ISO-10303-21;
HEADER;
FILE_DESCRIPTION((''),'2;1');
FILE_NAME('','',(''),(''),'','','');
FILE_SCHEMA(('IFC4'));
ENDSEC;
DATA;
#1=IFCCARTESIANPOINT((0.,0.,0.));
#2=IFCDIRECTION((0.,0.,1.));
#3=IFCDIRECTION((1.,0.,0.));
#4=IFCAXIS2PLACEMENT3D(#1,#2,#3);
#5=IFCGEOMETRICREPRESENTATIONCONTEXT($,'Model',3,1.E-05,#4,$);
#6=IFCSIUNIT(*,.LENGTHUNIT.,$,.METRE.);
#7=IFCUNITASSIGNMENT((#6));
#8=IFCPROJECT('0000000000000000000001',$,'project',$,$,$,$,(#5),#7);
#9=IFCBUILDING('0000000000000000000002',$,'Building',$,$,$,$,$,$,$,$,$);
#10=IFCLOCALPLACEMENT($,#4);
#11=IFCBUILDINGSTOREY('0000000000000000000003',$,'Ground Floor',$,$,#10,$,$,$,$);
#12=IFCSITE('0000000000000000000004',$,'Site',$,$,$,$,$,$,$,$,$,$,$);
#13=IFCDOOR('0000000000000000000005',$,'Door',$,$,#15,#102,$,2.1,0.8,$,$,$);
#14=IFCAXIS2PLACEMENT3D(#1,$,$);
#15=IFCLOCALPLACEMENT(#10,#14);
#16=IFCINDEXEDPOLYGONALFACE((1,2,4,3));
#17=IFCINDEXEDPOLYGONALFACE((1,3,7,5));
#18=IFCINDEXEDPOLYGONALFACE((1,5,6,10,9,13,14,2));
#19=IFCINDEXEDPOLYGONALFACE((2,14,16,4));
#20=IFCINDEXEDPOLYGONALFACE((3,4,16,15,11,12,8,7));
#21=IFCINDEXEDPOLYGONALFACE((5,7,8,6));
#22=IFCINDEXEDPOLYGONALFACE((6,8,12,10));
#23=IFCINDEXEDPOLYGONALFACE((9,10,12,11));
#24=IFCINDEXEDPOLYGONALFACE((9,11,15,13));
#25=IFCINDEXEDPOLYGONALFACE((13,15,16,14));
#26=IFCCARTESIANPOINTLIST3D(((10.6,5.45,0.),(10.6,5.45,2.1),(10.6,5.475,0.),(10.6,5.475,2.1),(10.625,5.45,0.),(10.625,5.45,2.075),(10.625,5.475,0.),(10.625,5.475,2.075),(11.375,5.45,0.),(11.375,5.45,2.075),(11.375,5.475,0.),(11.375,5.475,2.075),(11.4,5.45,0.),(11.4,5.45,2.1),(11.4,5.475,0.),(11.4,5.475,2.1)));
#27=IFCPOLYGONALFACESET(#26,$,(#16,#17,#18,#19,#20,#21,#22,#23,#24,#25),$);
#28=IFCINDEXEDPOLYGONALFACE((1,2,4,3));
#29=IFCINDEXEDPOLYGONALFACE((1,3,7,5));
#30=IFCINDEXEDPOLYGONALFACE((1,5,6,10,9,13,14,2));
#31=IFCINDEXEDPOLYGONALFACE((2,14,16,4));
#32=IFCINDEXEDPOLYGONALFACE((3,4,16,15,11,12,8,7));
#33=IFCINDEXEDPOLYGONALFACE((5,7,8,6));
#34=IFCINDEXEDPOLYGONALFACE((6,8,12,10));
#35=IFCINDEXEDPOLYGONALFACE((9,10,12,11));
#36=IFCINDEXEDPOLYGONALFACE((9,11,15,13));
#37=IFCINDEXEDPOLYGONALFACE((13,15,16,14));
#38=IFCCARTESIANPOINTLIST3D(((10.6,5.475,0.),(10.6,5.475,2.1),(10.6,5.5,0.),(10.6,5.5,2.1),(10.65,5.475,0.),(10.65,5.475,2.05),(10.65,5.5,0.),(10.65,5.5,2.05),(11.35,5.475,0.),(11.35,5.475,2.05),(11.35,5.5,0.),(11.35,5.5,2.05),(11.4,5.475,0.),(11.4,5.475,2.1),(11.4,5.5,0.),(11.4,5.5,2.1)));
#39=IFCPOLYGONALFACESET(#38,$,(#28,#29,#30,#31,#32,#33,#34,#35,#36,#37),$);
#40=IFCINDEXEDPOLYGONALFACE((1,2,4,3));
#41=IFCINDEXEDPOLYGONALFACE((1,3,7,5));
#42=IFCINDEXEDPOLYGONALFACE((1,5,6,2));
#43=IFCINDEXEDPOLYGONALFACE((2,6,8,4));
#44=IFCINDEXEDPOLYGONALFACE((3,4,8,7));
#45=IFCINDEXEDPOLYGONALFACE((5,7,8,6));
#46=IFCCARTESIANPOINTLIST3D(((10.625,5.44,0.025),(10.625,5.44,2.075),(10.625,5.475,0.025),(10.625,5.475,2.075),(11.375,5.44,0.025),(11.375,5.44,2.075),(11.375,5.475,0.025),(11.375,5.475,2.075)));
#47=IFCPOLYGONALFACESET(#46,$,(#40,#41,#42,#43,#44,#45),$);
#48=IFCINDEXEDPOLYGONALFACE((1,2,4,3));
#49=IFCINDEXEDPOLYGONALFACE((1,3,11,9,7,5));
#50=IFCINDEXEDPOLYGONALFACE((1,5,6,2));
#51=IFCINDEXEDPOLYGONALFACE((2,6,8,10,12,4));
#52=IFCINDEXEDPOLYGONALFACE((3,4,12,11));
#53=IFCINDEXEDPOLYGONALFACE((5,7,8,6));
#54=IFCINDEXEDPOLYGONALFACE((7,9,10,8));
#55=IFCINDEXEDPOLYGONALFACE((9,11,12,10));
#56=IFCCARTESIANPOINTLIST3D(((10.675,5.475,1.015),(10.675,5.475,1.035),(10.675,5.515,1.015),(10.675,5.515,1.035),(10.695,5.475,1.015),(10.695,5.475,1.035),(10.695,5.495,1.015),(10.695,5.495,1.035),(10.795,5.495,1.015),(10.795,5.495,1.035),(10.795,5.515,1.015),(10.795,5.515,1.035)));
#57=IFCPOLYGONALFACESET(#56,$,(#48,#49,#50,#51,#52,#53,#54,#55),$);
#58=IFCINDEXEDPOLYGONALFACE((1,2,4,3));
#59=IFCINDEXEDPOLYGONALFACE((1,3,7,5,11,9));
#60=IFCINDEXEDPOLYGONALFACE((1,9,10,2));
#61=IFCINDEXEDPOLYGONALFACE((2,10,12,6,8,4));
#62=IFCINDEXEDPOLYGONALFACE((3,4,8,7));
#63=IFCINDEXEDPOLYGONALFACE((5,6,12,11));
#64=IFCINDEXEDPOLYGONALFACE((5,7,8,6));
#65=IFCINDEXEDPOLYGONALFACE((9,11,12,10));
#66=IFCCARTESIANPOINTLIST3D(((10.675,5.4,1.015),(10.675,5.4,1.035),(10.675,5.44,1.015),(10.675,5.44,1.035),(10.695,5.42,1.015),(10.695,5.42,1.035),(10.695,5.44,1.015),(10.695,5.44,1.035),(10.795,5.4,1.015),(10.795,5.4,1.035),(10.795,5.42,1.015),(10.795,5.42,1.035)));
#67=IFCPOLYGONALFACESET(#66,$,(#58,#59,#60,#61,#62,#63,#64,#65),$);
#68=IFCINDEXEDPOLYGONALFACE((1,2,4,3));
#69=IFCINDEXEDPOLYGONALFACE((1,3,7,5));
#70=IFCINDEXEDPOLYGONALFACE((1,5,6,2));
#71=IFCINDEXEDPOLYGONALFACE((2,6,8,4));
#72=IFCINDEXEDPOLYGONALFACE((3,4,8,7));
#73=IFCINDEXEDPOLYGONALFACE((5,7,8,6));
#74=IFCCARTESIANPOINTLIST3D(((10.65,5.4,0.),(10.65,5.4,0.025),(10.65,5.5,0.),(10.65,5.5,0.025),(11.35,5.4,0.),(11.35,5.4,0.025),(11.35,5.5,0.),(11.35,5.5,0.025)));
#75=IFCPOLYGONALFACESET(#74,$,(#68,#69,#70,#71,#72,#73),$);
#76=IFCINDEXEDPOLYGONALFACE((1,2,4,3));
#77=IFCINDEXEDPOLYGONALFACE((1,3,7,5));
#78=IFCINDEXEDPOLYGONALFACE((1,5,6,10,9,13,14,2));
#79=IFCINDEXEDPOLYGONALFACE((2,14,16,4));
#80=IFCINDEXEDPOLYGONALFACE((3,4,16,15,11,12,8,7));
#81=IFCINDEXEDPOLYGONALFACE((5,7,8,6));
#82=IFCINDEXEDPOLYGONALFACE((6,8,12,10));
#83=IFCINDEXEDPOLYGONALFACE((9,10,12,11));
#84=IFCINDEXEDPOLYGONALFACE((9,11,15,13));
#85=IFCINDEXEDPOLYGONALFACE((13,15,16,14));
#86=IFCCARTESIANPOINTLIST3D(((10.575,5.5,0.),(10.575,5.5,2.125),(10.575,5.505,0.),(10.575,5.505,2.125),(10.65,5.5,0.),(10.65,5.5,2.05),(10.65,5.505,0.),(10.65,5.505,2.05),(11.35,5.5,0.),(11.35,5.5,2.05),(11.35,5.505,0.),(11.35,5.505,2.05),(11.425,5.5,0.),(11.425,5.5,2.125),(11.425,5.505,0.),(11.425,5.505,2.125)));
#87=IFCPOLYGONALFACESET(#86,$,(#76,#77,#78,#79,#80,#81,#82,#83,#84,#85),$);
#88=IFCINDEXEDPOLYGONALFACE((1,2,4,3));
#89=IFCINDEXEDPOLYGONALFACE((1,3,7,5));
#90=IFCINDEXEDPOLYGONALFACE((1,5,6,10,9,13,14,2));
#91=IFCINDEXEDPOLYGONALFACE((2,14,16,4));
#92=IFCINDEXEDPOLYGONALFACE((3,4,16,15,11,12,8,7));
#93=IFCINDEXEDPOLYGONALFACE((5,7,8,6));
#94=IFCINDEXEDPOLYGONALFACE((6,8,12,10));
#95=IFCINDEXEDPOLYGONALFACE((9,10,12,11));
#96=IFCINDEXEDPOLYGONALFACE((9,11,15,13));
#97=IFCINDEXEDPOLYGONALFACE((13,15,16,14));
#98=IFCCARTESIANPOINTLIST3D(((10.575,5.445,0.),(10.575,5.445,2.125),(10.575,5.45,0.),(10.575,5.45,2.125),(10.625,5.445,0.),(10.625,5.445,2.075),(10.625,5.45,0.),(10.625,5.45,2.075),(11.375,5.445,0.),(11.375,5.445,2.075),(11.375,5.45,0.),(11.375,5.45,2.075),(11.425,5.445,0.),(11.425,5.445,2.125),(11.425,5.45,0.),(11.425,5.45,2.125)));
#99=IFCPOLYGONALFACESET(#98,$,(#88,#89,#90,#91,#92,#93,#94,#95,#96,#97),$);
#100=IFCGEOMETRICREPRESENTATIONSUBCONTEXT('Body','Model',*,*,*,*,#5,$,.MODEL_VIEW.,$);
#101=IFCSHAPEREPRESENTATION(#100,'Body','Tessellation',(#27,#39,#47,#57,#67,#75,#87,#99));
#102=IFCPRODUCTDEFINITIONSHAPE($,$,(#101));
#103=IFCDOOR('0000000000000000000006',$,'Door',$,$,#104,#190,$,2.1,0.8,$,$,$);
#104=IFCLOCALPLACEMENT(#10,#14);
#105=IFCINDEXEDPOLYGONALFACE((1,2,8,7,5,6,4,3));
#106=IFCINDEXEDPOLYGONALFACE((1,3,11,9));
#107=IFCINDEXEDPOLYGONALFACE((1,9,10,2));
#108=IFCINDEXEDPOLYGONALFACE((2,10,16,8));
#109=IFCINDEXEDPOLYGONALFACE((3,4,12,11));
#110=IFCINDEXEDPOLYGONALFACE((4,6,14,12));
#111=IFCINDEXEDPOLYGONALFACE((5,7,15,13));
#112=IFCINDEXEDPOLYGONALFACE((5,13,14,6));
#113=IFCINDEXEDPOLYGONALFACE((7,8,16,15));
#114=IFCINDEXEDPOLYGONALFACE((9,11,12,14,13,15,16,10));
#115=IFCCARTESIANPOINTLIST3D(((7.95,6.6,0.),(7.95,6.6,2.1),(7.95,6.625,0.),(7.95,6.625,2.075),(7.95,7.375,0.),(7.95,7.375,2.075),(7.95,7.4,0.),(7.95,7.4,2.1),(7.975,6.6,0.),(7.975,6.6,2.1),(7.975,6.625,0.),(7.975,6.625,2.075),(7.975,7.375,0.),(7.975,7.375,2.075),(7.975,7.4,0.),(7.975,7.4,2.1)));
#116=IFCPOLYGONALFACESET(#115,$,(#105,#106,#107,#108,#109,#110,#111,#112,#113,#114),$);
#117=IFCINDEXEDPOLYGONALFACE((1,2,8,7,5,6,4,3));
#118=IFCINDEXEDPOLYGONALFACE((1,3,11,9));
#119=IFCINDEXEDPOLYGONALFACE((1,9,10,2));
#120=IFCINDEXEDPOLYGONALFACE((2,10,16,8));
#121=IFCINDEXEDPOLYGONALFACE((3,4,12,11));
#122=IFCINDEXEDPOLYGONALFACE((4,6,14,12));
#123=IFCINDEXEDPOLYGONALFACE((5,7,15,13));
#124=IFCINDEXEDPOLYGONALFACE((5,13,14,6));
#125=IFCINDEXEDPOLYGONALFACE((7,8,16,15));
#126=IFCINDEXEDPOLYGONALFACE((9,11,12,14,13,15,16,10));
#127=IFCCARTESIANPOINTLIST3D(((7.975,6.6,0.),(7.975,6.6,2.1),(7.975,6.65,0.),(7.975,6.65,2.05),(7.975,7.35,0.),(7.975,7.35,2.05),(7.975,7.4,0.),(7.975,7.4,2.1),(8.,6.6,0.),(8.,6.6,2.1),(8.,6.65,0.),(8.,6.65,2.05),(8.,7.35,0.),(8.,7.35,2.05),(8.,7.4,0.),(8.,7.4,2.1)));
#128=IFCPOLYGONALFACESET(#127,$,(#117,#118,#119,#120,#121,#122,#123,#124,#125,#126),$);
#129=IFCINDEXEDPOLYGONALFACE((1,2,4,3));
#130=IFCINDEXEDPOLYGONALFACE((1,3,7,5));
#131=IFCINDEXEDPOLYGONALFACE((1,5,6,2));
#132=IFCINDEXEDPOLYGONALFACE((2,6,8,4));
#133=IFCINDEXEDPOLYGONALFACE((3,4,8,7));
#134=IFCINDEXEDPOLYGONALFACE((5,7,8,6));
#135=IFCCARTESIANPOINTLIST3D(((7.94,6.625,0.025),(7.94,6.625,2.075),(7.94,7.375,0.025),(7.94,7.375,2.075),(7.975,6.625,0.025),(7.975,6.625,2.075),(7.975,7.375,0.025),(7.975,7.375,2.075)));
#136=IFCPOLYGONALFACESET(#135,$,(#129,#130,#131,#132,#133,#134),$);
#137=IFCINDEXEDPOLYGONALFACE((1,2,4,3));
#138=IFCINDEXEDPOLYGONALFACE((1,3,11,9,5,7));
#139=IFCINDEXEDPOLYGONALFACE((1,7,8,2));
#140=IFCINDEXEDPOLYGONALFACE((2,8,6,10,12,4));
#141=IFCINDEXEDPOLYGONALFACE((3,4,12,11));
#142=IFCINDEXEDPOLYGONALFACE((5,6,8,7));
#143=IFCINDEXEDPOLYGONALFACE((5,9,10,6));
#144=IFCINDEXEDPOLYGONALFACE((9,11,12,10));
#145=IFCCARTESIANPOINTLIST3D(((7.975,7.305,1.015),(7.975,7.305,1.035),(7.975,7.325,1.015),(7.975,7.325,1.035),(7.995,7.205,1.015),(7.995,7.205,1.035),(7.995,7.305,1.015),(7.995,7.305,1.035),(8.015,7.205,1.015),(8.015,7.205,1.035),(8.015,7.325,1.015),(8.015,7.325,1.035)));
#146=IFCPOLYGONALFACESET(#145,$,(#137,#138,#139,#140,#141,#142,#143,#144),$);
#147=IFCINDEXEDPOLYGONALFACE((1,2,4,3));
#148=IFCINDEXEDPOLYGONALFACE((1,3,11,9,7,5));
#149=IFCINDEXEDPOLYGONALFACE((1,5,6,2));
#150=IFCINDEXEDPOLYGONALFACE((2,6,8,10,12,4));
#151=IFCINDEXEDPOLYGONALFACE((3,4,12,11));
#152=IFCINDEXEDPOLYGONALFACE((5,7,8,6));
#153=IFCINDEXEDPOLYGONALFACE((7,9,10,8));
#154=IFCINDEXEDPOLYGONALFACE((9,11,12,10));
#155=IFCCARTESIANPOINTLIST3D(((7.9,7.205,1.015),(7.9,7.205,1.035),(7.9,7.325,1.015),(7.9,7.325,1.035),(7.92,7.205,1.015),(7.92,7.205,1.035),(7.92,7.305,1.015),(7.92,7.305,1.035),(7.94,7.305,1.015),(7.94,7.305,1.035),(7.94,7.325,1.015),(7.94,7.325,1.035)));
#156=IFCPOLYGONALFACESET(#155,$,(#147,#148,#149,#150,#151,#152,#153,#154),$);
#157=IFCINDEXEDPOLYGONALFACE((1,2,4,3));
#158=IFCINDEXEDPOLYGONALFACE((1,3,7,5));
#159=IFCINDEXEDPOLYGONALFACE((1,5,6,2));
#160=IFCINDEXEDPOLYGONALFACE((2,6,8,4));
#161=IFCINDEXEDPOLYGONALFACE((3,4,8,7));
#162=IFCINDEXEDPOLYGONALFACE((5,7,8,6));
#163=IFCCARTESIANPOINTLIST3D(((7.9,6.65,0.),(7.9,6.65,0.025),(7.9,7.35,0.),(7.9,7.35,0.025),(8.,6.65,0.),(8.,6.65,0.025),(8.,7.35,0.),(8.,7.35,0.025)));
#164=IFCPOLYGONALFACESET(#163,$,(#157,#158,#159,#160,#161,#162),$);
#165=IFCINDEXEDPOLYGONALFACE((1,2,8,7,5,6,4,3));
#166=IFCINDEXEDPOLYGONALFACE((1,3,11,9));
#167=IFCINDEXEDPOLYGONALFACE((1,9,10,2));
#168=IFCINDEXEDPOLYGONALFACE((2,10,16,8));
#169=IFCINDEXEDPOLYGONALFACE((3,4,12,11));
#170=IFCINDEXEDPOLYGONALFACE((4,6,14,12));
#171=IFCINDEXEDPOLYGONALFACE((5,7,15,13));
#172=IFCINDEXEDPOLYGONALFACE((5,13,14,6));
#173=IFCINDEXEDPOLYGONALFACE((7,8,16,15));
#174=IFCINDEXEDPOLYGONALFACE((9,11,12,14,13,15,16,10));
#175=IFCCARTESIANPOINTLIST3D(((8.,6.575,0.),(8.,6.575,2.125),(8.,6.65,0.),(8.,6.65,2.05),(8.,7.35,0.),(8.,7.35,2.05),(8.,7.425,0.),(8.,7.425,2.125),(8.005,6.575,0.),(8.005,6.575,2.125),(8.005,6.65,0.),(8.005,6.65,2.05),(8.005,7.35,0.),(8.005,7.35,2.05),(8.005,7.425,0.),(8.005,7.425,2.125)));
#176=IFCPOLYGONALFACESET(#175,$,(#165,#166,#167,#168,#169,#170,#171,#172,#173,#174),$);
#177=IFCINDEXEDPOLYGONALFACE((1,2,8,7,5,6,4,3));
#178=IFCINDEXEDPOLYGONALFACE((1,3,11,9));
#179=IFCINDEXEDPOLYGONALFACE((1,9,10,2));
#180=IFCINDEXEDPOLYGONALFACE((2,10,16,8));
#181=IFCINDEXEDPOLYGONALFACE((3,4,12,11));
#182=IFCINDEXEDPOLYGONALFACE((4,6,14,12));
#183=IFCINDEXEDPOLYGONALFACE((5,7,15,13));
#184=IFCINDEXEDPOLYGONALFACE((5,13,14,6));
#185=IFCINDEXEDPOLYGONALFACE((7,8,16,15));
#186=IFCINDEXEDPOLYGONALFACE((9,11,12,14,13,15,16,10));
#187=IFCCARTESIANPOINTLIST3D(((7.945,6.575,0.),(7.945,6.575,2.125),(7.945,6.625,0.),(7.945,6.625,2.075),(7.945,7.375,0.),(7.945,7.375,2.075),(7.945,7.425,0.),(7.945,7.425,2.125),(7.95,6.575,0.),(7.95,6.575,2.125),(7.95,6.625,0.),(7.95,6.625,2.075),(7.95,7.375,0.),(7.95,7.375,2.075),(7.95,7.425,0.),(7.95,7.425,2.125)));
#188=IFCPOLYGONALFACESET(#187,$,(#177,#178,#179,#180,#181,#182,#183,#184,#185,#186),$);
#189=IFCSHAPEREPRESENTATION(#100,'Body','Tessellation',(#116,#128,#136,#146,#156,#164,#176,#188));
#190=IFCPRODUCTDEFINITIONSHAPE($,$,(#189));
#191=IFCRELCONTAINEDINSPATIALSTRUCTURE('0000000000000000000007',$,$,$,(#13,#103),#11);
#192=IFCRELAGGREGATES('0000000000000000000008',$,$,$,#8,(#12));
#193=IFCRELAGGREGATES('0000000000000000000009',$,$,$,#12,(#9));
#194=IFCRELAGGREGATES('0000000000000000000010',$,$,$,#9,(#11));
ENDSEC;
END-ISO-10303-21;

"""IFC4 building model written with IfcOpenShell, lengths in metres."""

from ifc_helpers import new_model, si_unit, frame, origin_with_axes, place, context, subcontext, project, spatial, line, indexed_curve, outline, extrude, element, save


model = new_model("IFC4")

# Units and contexts
model_context = context("Model", 3, precision=1e-05, world=origin_with_axes())
body_context = subcontext(model_context, "Body", "Model", "MODEL_VIEW")
ifc_project = project(units=[si_unit("LENGTHUNIT", "METRE")], contexts=[model_context])

# Site, building, storey
site = spatial("IfcSite", under=ifc_project, Name="Site")
building = spatial("IfcBuilding", under=site, Name="Building")
storey_placement = place(None, origin_with_axes())
storey = spatial("IfcBuildingStorey", under=building, at=storey_placement, Name="Ground Floor")

# Doors
door_1_placement = place(storey_placement, frame((11.4, 5.5, 0.0), z_axis=(0.0, 0.0, 1.0), x_axis=(-1.0, 0.0, 0.0)))
element("IfcDoor", 1, at=door_1_placement, inside=storey, Name="Door", OverallHeight=2.1, OverallWidth=0.8, context=body_context, shape_type="SweptSolid", body=[
    extrude(outline(indexed_curve([(0.0, 0.0), (0.0, 2.1), (0.8, 2.1), (0.8, 0.0), (0.775, 0.0), (0.775, 2.075), (0.025, 2.075), (0.025, 0.0)], segments=[line(1, 2, 3, 4, 5, 6, 7, 8, 1)])), frame((0.0, 0.025, 0.0), z_axis=(0.0, -1.0, 0.0), x_axis=(1.0, 0.0, 0.0)), (0.0, 0.0, -1.0), 0.025),
    extrude(outline(indexed_curve([(0.0, 0.0), (0.0, 2.1), (0.8, 2.1), (0.8, 0.0), (0.75, 0.0), (0.75, 2.05), (0.05, 2.05), (0.05, 0.0)], segments=[line(1, 2, 3, 4, 5, 6, 7, 8, 1)])), frame((0.0, 0.0, 0.0), z_axis=(0.0, -1.0, 0.0), x_axis=(1.0, 0.0, 0.0)), (0.0, 0.0, -1.0), 0.025),
    extrude(outline(indexed_curve([(0.0, 0.0), (0.75, 0.0), (0.75, 0.035), (0.0, 0.035)], segments=[line(1, 2, 3, 4, 1)])), frame((0.025, 0.025, 0.025), z_axis=(0.0, 0.0, 1.0), x_axis=(1.0, 0.0, 0.0)), (0.0, 0.0, 1.0), 2.05),
    extrude(outline(indexed_curve([(0.0, 0.0), (0.0, -0.04), (-0.12, -0.04), (-0.12, -0.02), (-0.02, -0.02), (-0.02, 0.0)], segments=[line(1, 2, 3, 4, 5, 6, 1)])), frame((0.725, 0.025, 1.015), z_axis=(0.0, 0.0, 1.0), x_axis=(1.0, 0.0, 0.0)), (0.0, 0.0, 1.0), 0.02),
    extrude(outline(indexed_curve([(0.0, 0.0), (0.0, 0.04), (-0.12, 0.04), (-0.12, 0.02), (-0.02, 0.02), (-0.02, 0.0)], segments=[line(1, 2, 3, 4, 5, 6, 1)])), frame((0.725, 0.06, 1.015), z_axis=(0.0, 0.0, 1.0), x_axis=(1.0, 0.0, 0.0)), (0.0, 0.0, 1.0), 0.02),
    extrude(outline(indexed_curve([(0.0, 0.0), (0.7, 0.0), (0.7, 0.1), (0.0, 0.1)], segments=[line(1, 2, 3, 4, 1)])), frame((0.05, 0.0, 0.0), z_axis=(0.0, 0.0, 1.0), x_axis=(1.0, 0.0, 0.0)), (0.0, 0.0, 1.0), 0.025),
    extrude(outline(indexed_curve([(0.0, 0.0), (0.0, 2.125), (0.85, 2.125), (0.85, 0.0), (0.775, 0.0), (0.775, 2.05), (0.075, 2.05), (0.075, 0.0)], segments=[line(1, 2, 3, 4, 5, 6, 7, 8, 1)])), frame((-0.025, -0.005, 0.0), z_axis=(0.0, -1.0, 0.0), x_axis=(1.0, 0.0, 0.0)), (0.0, 0.0, -1.0), 0.005),
    extrude(outline(indexed_curve([(0.0, 0.0), (0.0, 2.125), (0.85, 2.125), (0.85, 0.0), (0.8, 0.0), (0.8, 2.075), (0.05, 2.075), (0.05, 0.0)], segments=[line(1, 2, 3, 4, 5, 6, 7, 8, 1)])), frame((-0.025, 0.05, 0.0), z_axis=(0.0, -1.0, 0.0), x_axis=(1.0, 0.0, 0.0)), (0.0, 0.0, -1.0), 0.005),
])
door_2_placement = place(storey_placement, frame((8.0, 6.6, 0.0), z_axis=(0.0, 0.0, 1.0), x_axis=(0.0, 1.0, 0.0)))
element("IfcDoor", 2, at=door_2_placement, inside=storey, Name="Door", OverallHeight=2.1, OverallWidth=0.8, context=body_context, shape_type="SweptSolid", body=[
    extrude(outline(indexed_curve([(0.0, 0.0), (0.0, 2.1), (0.8, 2.1), (0.8, 0.0), (0.775, 0.0), (0.775, 2.075), (0.025, 2.075), (0.025, 0.0)], segments=[line(1, 2, 3, 4, 5, 6, 7, 8, 1)])), frame((0.0, 0.025, 0.0), z_axis=(0.0, -1.0, 0.0), x_axis=(1.0, 0.0, 0.0)), (0.0, 0.0, -1.0), 0.025),
    extrude(outline(indexed_curve([(0.0, 0.0), (0.0, 2.1), (0.8, 2.1), (0.8, 0.0), (0.75, 0.0), (0.75, 2.05), (0.05, 2.05), (0.05, 0.0)], segments=[line(1, 2, 3, 4, 5, 6, 7, 8, 1)])), frame((0.0, 0.0, 0.0), z_axis=(0.0, -1.0, 0.0), x_axis=(1.0, 0.0, 0.0)), (0.0, 0.0, -1.0), 0.025),
    extrude(outline(indexed_curve([(0.0, 0.0), (0.75, 0.0), (0.75, 0.035), (0.0, 0.035)], segments=[line(1, 2, 3, 4, 1)])), frame((0.025, 0.025, 0.025), z_axis=(0.0, 0.0, 1.0), x_axis=(1.0, 0.0, 0.0)), (0.0, 0.0, 1.0), 2.05),
    extrude(outline(indexed_curve([(0.0, 0.0), (0.0, -0.04), (-0.12, -0.04), (-0.12, -0.02), (-0.02, -0.02), (-0.02, 0.0)], segments=[line(1, 2, 3, 4, 5, 6, 1)])), frame((0.725, 0.025, 1.015), z_axis=(0.0, 0.0, 1.0), x_axis=(1.0, 0.0, 0.0)), (0.0, 0.0, 1.0), 0.02),
    extrude(outline(indexed_curve([(0.0, 0.0), (0.0, 0.04), (-0.12, 0.04), (-0.12, 0.02), (-0.02, 0.02), (-0.02, 0.0)], segments=[line(1, 2, 3, 4, 5, 6, 1)])), frame((0.725, 0.06, 1.015), z_axis=(0.0, 0.0, 1.0), x_axis=(1.0, 0.0, 0.0)), (0.0, 0.0, 1.0), 0.02),
    extrude(outline(indexed_curve([(0.0, 0.0), (0.7, 0.0), (0.7, 0.1), (0.0, 0.1)], segments=[line(1, 2, 3, 4, 1)])), frame((0.05, 0.0, 0.0), z_axis=(0.0, 0.0, 1.0), x_axis=(1.0, 0.0, 0.0)), (0.0, 0.0, 1.0), 0.025),
    extrude(outline(indexed_curve([(0.0, 0.0), (0.0, 2.125), (0.85, 2.125), (0.85, 0.0), (0.775, 0.0), (0.775, 2.05), (0.075, 2.05), (0.075, 0.0)], segments=[line(1, 2, 3, 4, 5, 6, 7, 8, 1)])), frame((-0.025, -0.005, 0.0), z_axis=(0.0, -1.0, 0.0), x_axis=(1.0, 0.0, 0.0)), (0.0, 0.0, -1.0), 0.005),
    extrude(outline(indexed_curve([(0.0, 0.0), (0.0, 2.125), (0.85, 2.125), (0.85, 0.0), (0.8, 0.0), (0.8, 2.075), (0.05, 2.075), (0.05, 0.0)], segments=[line(1, 2, 3, 4, 5, 6, 7, 8, 1)])), frame((-0.025, 0.05, 0.0), z_axis=(0.0, -1.0, 0.0), x_axis=(1.0, 0.0, 0.0)), (0.0, 0.0, -1.0), 0.005),
])

save(model, "model.ifc")
